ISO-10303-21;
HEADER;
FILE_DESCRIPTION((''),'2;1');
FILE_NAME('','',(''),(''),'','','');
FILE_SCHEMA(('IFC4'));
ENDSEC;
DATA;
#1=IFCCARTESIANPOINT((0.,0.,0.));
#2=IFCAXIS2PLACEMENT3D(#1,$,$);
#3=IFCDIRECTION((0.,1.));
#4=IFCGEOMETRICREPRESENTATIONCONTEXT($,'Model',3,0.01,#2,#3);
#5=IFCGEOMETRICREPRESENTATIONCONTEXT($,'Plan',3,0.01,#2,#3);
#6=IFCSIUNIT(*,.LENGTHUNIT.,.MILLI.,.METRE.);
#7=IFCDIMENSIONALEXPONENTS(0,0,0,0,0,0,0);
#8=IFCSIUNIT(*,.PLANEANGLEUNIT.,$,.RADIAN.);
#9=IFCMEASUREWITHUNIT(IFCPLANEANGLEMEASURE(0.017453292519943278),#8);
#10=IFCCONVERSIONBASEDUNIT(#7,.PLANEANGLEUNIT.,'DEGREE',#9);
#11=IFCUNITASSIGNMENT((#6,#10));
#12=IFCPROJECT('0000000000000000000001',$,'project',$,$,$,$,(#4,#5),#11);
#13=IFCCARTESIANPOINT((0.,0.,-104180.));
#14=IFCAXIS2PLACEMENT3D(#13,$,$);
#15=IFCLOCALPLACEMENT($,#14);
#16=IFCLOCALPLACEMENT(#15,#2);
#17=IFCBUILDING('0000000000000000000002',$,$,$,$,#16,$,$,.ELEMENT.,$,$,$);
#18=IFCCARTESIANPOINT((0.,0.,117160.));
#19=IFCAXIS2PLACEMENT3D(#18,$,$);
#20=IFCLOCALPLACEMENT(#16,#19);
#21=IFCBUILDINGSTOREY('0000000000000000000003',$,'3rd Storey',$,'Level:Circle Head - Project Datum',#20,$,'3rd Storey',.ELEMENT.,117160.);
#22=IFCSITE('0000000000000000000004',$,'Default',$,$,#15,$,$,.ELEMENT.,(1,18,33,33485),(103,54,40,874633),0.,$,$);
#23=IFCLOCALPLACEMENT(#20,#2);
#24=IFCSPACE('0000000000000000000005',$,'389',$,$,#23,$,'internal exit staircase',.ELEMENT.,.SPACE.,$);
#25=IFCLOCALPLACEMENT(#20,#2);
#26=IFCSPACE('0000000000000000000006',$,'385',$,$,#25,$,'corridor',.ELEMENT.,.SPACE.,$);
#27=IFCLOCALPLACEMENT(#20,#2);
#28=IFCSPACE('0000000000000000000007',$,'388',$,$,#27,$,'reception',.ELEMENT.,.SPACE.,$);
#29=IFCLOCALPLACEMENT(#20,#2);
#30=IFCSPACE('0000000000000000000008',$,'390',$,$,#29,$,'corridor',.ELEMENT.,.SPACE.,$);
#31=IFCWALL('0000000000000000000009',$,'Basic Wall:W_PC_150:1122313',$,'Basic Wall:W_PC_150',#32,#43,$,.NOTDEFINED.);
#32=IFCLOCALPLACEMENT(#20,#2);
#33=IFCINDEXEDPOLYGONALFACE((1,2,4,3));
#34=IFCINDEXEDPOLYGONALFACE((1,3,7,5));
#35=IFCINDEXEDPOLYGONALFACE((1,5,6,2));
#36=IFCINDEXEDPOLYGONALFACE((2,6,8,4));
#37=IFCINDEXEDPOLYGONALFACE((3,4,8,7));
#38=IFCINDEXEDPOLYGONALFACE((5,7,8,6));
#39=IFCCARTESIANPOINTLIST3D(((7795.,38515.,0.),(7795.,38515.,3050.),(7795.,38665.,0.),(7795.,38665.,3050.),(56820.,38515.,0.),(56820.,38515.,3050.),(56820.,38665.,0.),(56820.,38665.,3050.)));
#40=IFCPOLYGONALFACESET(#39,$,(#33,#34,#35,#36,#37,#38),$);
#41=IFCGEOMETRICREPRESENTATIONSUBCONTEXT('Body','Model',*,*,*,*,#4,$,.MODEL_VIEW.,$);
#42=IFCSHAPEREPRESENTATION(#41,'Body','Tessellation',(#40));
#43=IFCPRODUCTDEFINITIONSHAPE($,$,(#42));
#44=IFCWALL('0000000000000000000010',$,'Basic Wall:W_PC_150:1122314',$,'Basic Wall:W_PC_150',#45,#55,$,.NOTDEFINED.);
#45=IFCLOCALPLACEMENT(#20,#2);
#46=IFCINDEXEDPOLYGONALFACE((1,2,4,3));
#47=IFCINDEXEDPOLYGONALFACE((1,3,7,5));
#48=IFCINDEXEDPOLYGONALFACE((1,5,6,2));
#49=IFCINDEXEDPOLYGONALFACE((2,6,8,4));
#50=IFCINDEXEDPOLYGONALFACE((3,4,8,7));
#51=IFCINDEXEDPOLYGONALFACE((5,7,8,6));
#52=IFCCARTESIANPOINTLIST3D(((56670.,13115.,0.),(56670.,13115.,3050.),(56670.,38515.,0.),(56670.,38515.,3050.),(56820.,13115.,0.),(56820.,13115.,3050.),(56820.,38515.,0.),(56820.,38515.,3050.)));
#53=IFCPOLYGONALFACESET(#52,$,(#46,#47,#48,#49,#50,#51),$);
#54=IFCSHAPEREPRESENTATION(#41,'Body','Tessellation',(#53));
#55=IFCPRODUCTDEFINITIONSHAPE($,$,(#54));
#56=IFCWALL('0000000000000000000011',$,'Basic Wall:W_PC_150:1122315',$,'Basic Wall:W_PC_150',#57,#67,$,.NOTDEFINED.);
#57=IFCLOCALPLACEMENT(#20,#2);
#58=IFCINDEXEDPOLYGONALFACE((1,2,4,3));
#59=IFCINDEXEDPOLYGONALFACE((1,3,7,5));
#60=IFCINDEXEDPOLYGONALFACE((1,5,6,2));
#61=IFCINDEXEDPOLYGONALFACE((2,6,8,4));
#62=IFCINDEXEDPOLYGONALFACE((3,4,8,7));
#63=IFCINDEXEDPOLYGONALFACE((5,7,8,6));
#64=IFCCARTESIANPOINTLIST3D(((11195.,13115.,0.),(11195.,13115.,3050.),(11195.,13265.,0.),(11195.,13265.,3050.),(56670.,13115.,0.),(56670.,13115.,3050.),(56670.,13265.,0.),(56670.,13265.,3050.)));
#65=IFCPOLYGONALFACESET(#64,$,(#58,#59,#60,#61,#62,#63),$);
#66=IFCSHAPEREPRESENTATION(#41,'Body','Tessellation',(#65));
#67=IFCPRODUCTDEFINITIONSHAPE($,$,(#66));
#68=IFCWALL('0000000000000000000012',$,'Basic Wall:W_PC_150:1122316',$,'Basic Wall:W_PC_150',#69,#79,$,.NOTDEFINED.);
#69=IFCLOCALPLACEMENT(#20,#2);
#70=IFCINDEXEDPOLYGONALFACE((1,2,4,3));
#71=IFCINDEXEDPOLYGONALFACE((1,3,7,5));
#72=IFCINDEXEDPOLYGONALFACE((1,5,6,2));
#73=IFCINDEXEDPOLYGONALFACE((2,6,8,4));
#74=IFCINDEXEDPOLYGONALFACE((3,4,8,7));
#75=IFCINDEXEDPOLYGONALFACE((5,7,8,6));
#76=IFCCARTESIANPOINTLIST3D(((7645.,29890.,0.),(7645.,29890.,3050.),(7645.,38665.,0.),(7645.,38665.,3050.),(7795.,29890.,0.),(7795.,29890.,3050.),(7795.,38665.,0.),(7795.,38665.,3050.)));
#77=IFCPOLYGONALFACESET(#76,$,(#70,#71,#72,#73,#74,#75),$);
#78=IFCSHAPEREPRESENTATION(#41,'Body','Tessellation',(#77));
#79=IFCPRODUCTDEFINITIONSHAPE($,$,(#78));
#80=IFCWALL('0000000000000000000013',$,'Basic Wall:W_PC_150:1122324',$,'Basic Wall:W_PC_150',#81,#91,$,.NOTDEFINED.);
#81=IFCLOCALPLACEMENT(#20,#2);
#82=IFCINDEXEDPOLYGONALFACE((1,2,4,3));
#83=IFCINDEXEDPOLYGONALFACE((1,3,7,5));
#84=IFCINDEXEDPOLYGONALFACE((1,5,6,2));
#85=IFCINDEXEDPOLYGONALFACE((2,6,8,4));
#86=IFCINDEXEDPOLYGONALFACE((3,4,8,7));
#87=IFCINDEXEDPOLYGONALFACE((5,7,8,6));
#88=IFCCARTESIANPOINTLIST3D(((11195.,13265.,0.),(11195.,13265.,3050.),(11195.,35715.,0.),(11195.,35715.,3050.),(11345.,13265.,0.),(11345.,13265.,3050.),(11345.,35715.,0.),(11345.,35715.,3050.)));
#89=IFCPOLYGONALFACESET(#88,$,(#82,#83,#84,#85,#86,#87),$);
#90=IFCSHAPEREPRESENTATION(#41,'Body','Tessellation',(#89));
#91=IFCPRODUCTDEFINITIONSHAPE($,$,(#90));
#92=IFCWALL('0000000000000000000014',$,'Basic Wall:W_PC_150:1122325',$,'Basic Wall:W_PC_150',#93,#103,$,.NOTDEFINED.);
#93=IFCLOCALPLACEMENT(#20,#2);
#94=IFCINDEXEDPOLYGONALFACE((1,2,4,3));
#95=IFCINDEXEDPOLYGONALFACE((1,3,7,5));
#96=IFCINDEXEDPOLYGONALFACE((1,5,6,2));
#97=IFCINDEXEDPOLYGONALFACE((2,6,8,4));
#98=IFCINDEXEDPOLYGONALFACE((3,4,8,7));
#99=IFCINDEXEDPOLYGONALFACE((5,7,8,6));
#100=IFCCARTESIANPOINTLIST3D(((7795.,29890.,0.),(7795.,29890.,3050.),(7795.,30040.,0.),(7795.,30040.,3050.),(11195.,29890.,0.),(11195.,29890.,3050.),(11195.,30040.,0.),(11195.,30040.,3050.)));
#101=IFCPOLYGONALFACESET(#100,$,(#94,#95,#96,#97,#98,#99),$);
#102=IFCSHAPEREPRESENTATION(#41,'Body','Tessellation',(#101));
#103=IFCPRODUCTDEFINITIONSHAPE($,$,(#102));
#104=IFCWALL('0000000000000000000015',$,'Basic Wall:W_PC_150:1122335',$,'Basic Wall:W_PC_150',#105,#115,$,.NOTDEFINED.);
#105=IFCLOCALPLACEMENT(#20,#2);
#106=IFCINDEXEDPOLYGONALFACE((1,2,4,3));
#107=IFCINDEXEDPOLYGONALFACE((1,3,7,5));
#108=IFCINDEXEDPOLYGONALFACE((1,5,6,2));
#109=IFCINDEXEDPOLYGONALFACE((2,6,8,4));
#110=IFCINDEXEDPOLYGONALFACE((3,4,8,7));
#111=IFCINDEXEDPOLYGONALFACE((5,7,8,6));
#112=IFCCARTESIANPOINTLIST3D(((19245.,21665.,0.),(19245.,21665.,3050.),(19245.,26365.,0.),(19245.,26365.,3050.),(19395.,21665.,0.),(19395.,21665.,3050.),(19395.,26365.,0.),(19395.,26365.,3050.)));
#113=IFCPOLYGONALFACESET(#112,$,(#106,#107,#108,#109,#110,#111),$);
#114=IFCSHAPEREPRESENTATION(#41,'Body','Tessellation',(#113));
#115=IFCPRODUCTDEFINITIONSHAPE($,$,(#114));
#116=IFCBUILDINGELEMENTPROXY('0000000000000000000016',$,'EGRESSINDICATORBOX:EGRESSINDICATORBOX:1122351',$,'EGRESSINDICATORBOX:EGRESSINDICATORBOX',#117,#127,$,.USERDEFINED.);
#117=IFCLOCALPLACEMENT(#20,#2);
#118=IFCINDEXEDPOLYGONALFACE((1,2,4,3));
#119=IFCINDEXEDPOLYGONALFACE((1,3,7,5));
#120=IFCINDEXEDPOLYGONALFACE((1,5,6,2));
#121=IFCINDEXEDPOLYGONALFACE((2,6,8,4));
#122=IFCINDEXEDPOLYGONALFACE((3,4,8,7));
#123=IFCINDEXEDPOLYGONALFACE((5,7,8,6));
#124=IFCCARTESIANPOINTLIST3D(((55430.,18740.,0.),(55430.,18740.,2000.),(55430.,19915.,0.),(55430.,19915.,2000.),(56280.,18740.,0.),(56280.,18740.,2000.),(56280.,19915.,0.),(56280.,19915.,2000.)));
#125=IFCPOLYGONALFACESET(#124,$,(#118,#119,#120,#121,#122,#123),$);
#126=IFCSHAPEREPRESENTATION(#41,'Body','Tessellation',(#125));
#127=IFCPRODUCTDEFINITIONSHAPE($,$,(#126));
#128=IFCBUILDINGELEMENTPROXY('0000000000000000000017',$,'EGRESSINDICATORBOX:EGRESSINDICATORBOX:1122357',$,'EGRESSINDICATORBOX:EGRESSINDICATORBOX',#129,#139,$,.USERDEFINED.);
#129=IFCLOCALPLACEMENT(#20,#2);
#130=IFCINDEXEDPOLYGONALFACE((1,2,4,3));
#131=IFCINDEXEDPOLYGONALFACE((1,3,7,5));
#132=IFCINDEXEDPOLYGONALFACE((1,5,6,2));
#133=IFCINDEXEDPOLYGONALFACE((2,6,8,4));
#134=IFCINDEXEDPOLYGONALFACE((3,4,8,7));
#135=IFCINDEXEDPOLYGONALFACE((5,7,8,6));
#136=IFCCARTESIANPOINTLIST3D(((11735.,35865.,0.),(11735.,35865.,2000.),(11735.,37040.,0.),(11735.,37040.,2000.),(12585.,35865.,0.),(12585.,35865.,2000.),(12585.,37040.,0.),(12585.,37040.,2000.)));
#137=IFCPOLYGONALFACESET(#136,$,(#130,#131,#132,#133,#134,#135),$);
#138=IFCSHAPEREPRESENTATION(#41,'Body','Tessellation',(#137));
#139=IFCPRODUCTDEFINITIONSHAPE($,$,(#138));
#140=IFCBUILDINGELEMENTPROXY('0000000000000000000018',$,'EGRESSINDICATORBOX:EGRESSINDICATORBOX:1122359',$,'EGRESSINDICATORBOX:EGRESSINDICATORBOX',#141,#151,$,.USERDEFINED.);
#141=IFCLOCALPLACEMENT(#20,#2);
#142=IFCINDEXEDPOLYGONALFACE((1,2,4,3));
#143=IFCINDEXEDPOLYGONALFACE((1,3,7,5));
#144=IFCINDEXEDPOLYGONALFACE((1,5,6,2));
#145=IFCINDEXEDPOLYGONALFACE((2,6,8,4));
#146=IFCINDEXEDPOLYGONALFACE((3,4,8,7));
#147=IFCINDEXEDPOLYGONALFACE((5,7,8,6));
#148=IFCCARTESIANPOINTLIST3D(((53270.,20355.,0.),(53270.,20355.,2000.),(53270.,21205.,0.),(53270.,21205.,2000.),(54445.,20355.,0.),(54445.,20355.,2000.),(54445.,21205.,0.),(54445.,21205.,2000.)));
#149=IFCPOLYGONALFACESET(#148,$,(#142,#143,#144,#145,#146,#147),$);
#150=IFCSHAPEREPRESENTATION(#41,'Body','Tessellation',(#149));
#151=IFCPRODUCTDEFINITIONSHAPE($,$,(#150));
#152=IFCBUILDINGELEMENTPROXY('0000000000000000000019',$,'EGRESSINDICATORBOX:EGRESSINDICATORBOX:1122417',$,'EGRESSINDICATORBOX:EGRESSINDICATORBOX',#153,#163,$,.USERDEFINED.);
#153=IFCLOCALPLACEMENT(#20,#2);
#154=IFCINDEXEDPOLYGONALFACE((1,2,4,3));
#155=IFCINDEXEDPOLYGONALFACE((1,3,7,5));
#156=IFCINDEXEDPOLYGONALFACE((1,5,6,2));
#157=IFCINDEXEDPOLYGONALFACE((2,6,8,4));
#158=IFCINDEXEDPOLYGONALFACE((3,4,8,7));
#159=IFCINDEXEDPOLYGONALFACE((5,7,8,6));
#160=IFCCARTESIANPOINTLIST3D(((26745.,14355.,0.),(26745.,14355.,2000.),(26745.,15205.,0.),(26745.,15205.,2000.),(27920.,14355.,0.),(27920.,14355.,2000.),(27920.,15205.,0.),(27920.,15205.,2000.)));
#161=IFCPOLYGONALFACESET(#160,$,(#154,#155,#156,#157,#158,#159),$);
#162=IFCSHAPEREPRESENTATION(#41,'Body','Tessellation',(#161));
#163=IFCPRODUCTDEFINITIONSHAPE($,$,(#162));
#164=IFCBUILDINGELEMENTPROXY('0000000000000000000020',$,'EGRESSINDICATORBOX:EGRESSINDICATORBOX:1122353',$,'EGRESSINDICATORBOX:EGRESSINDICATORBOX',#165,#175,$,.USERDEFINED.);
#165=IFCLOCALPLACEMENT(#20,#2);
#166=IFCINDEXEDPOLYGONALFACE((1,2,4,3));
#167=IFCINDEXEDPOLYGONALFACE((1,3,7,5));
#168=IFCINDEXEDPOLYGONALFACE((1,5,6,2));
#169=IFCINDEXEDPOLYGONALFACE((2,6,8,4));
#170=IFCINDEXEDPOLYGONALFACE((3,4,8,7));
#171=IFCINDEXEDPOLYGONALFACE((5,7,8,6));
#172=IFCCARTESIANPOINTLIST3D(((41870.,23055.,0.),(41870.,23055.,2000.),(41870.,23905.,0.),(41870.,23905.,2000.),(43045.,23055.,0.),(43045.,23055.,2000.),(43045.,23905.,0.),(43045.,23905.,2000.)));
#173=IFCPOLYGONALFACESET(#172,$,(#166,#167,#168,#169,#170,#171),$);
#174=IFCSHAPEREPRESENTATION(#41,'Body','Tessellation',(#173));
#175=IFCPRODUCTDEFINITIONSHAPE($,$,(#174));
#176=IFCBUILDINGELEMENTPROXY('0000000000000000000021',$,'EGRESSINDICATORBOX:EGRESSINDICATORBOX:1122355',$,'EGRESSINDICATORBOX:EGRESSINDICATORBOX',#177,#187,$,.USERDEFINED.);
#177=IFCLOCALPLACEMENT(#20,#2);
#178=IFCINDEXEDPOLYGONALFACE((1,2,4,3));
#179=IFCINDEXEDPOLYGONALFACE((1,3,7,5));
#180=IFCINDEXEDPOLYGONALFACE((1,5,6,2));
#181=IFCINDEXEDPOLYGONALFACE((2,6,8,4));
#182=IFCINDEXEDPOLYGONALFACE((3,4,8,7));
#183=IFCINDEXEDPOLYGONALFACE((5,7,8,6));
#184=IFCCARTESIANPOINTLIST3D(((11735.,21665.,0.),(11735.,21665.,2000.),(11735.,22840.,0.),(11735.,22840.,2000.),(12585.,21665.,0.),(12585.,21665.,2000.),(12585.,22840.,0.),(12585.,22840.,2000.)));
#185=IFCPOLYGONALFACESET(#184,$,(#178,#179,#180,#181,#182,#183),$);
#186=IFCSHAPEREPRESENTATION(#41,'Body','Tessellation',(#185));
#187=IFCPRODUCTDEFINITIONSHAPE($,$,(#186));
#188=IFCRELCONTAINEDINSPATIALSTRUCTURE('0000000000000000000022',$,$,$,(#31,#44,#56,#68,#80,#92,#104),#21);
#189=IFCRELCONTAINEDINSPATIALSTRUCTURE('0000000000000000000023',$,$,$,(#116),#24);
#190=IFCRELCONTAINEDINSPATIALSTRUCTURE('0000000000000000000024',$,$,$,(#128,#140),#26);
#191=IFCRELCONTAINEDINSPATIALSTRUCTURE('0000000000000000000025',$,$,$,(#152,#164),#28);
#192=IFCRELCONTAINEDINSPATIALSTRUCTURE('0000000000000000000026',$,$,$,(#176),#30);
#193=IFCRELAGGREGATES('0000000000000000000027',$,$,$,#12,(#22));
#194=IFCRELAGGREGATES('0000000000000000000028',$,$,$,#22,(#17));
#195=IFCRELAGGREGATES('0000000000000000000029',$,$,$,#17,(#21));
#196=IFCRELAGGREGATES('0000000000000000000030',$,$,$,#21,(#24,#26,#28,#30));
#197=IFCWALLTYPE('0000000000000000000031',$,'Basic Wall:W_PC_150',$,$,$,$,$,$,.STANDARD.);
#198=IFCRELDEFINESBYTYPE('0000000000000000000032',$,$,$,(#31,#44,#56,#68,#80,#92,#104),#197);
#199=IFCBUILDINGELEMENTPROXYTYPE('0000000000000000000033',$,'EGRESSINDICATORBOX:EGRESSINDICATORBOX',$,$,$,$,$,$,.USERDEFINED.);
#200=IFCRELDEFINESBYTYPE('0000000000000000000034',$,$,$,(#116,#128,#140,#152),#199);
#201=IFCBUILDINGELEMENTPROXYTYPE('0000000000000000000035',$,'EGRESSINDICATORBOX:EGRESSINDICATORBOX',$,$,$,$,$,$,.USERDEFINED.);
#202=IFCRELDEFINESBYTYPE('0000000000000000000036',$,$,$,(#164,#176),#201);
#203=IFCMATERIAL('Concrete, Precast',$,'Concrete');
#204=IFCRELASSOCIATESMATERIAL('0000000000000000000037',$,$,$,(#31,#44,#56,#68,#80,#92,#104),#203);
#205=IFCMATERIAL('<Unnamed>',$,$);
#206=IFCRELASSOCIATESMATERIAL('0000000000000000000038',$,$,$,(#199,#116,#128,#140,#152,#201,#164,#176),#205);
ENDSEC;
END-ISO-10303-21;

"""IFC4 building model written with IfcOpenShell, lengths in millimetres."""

from ifc_helpers import new_model, entity, si_unit, converted_unit, direction, frame, origin, place, context, subcontext, project, spatial, indexed_curve, outline, extrude, source, transform, mapped, material, type_object, type_shapes, element, save


model = new_model("IFC4")

# Units and contexts
model_context = context("Model", 3, precision=0.01, world=origin(), true_north=direction((0.0, 1.0)))
plan_context = context("Plan", 3, precision=0.01, world=origin(), true_north=direction((0.0, 1.0)))
body_context = subcontext(model_context, "Body", "Model", "MODEL_VIEW")
ifc_project = project(units=[si_unit("LENGTHUNIT", "METRE", prefix="MILLI"), converted_unit("PLANEANGLEUNIT", "DEGREE", entity("IfcPlaneAngleMeasure", 0.017453292519943278), si_unit("PLANEANGLEUNIT", "RADIAN"), dimensions=[0, 0, 0, 0, 0, 0, 0])], contexts=[model_context, plan_context])

# Site, building, storey
site_placement = place(None, frame((0.0, 0.0, -104180.0)))
site = spatial("IfcSite", under=ifc_project, at=site_placement, Name="Default", CompositionType="ELEMENT", RefLatitude=(1, 18, 33, 33485), RefLongitude=(103, 54, 40, 874633), RefElevation=0.0)
building_placement = place(site_placement, origin())
building = spatial("IfcBuilding", under=site, at=building_placement, CompositionType="ELEMENT")
storey_placement = place(building_placement, frame((0.0, 0.0, 117160.0)))
storey = spatial("IfcBuildingStorey", under=building, at=storey_placement, Name="3rd Storey", ObjectType="Level:Circle Head - Project Datum", LongName="3rd Storey", CompositionType="ELEMENT", Elevation=117160.0)

# Shared definitions
ifc_material_1 = material(Name="Concrete, Precast", Category="Concrete")

# Walls
wall_type = type_object("IfcWallType", Name="Basic Wall:W_PC_150", PredefinedType="STANDARD")
wall_1_placement = place(storey_placement, frame((56820.0, 38590.0, 0.0), z_axis=(0.0, 0.0, 1.0), x_axis=(-1.0, 0.0, 0.0)))
element("IfcWall", 1, at=wall_1_placement, inside=storey, type_object=wall_type, material=ifc_material_1, Name="Basic Wall:W_PC_150:1122313", ObjectType="Basic Wall:W_PC_150", PredefinedType="NOTDEFINED", context=body_context, shape_type="SweptSolid", body=[
    extrude(outline(indexed_curve([(49025.0, 75.0), (0.0, 75.0), (0.0, -75.0), (49025.0, -75.0), (49025.0, 75.0)], self_intersect=False)), origin(), (0.0, 0.0, 1.0), 3050.0),
])
wall_2_placement = place(storey_placement, frame((56745.0, 13115.0, 0.0), z_axis=(0.0, 0.0, 1.0), x_axis=(0.0, 1.0, 0.0)))
element("IfcWall", 2, at=wall_2_placement, inside=storey, type_object=wall_type, material=ifc_material_1, Name="Basic Wall:W_PC_150:1122314", ObjectType="Basic Wall:W_PC_150", PredefinedType="NOTDEFINED", context=body_context, shape_type="SweptSolid", body=[
    extrude(outline(indexed_curve([(25400.0, 75.0), (0.0, 75.0), (0.0, -75.0), (25400.0, -75.0), (25400.0, 75.0)], self_intersect=False)), origin(), (0.0, 0.0, 1.0), 3050.0),
])
wall_3_placement = place(storey_placement, frame((11195.0, 13190.0, 0.0)))
element("IfcWall", 3, at=wall_3_placement, inside=storey, type_object=wall_type, material=ifc_material_1, Name="Basic Wall:W_PC_150:1122315", ObjectType="Basic Wall:W_PC_150", PredefinedType="NOTDEFINED", context=body_context, shape_type="SweptSolid", body=[
    extrude(outline(indexed_curve([(45475.0, 75.0), (0.0, 75.0), (0.0, -75.0), (45475.0, -75.0), (45475.0, 75.0)], self_intersect=False)), origin(), (0.0, 0.0, 1.0), 3050.0),
])
wall_4_placement = place(storey_placement, frame((7720.0, 38665.0, 0.0), z_axis=(0.0, 0.0, 1.0), x_axis=(0.0, -1.0, 0.0)))
element("IfcWall", 4, at=wall_4_placement, inside=storey, type_object=wall_type, material=ifc_material_1, Name="Basic Wall:W_PC_150:1122316", ObjectType="Basic Wall:W_PC_150", PredefinedType="NOTDEFINED", context=body_context, shape_type="SweptSolid", body=[
    extrude(outline(indexed_curve([(8775.0, 75.0), (0.0, 75.0), (0.0, -75.0), (8775.0, -75.0), (8775.0, 75.0)], self_intersect=False)), origin(), (0.0, 0.0, 1.0), 3050.0),
])
wall_5_placement = place(storey_placement, frame((11270.0, 35715.0, 0.0), z_axis=(0.0, 0.0, 1.0), x_axis=(0.0, -1.0, 0.0)))
element("IfcWall", 5, at=wall_5_placement, inside=storey, type_object=wall_type, material=ifc_material_1, Name="Basic Wall:W_PC_150:1122324", ObjectType="Basic Wall:W_PC_150", PredefinedType="NOTDEFINED", context=body_context, shape_type="SweptSolid", body=[
    extrude(outline(indexed_curve([(22450.0, 75.0), (0.0, 75.0), (0.0, -75.0), (22450.0, -75.0), (22450.0, 75.0)], self_intersect=False)), origin(), (0.0, 0.0, 1.0), 3050.0),
])
wall_6_placement = place(storey_placement, frame((7795.0, 29965.0, 0.0)))
element("IfcWall", 6, at=wall_6_placement, inside=storey, type_object=wall_type, material=ifc_material_1, Name="Basic Wall:W_PC_150:1122325", ObjectType="Basic Wall:W_PC_150", PredefinedType="NOTDEFINED", context=body_context, shape_type="SweptSolid", body=[
    extrude(outline(indexed_curve([(3400.0, 75.0), (0.0, 75.0), (0.0, -75.0), (3400.0, -75.0), (3400.0, 75.0)], self_intersect=False)), origin(), (0.0, 0.0, 1.0), 3050.0),
])
wall_7_placement = place(storey_placement, frame((19320.0, 21665.0, 0.0), z_axis=(0.0, 0.0, 1.0), x_axis=(0.0, 1.0, 0.0)))
element("IfcWall", 7, at=wall_7_placement, inside=storey, type_object=wall_type, material=ifc_material_1, Name="Basic Wall:W_PC_150:1122335", ObjectType="Basic Wall:W_PC_150", PredefinedType="NOTDEFINED", context=body_context, shape_type="SweptSolid", body=[
    extrude(outline(indexed_curve([(4700.0, 75.0), (0.0, 75.0), (0.0, -75.0), (4700.0, -75.0), (4700.0, 75.0)], self_intersect=False)), origin(), (0.0, 0.0, 1.0), 3050.0),
])

# Shared definitions
space_1_placement = place(storey_placement, origin())
space_1 = spatial("IfcSpace", under=storey, at=space_1_placement, Name="389", LongName="internal exit staircase", CompositionType="ELEMENT", PredefinedType="SPACE")

# Building element proxy
ifc_material_2 = material(Name="<Unnamed>")
building_element_proxy_type_1 = type_object("IfcBuildingElementProxyType", Name="EGRESSINDICATORBOX:EGRESSINDICATORBOX", PredefinedType="USERDEFINED", material=ifc_material_2)
shared_shape_1 = source(origin(), body_context, "Body", "SweptSolid", [
    extrude(outline(indexed_curve([(-587.5, -425.0), (587.5, -425.0), (587.5, 425.0), (-587.5, 425.0), (-587.5, -425.0)], self_intersect=False)), frame((0.0, 0.0, 0.0), z_axis=(0.0, 0.0, 1.0), x_axis=(0.0, 1.0, 0.0)), (0.0, 0.0, 1.0), 2000.0),
])
type_shapes(building_element_proxy_type_1, [shared_shape_1])
proxy_1_placement = place(space_1_placement, frame((55855.0, 19327.5, 0.0)))
element("IfcBuildingElementProxy", 8, at=proxy_1_placement, inside=space_1, type_object=building_element_proxy_type_1, material=ifc_material_2, Name="EGRESSINDICATORBOX:EGRESSINDICATORBOX:1122351", ObjectType="EGRESSINDICATORBOX:EGRESSINDICATORBOX", PredefinedType="USERDEFINED", context=body_context, shape_type="MappedRepresentation", body=[
    mapped(shared_shape_1, transform((0.0, 0.0, 0.0), scale=1.0)),
])

# Shared definitions
space_2_placement = place(storey_placement, origin())
space_2 = spatial("IfcSpace", under=storey, at=space_2_placement, Name="385", LongName="corridor", CompositionType="ELEMENT", PredefinedType="SPACE")

# Building element proxies
for number, where, z_axis, x_axis, name in (
    (9, (12160.0, 36452.5, 0.0), (0.0, 0.0, 1.0), (-1.0, 0.0, 0.0), "EGRESSINDICATORBOX:EGRESSINDICATORBOX:1122357"),
    (10, (53857.5, 20780.0, 0.0), (0.0, 0.0, 1.0), (0.0, 1.0, 0.0), "EGRESSINDICATORBOX:EGRESSINDICATORBOX:1122359"),
):
    element("IfcBuildingElementProxy", number, at=place(space_2_placement, frame(where, z_axis=z_axis, x_axis=x_axis)), inside=space_2, type_object=building_element_proxy_type_1, material=ifc_material_2, Name=name, ObjectType="EGRESSINDICATORBOX:EGRESSINDICATORBOX", PredefinedType="USERDEFINED", context=body_context, shape_type="MappedRepresentation", body=[
        mapped(shared_shape_1, transform((0.0, 0.0, 0.0), scale=1.0)),
    ])

# Shared definitions
space_3_placement = place(storey_placement, origin())
space_3 = spatial("IfcSpace", under=storey, at=space_3_placement, Name="388", LongName="reception", CompositionType="ELEMENT", PredefinedType="SPACE")

# Building element proxies
proxy_2_placement = place(space_3_placement, frame((27332.5, 14780.0, 0.0), z_axis=(0.0, 0.0, 1.0), x_axis=(0.0, 1.0, 0.0)))
element("IfcBuildingElementProxy", 11, at=proxy_2_placement, inside=space_3, type_object=building_element_proxy_type_1, material=ifc_material_2, Name="EGRESSINDICATORBOX:EGRESSINDICATORBOX:1122417", ObjectType="EGRESSINDICATORBOX:EGRESSINDICATORBOX", PredefinedType="USERDEFINED", context=body_context, shape_type="MappedRepresentation", body=[
    mapped(shared_shape_1, transform((0.0, 0.0, 0.0), scale=1.0)),
])
building_element_proxy_type_2 = type_object("IfcBuildingElementProxyType", Name="EGRESSINDICATORBOX:EGRESSINDICATORBOX", PredefinedType="USERDEFINED", material=ifc_material_2)
shared_shape_2 = source(origin(), body_context, "Body", "SweptSolid", [
    extrude(outline(indexed_curve([(-425.0, -587.5), (425.0, -587.5), (425.0, 587.5), (-425.0, 587.5), (-425.0, -587.5)], self_intersect=False)), frame((0.0, 0.0, 0.0), z_axis=(0.0, 0.0, 1.0), x_axis=(-1.0, 0.0, 0.0)), (0.0, 0.0, 1.0), 2000.0),
])
type_shapes(building_element_proxy_type_2, [shared_shape_2])
proxy_3_placement = place(space_3_placement, frame((42457.5, 23480.0, 0.0), z_axis=(0.0, 0.0, 1.0), x_axis=(0.0, -1.0, 0.0)))
element("IfcBuildingElementProxy", 12, at=proxy_3_placement, inside=space_3, type_object=building_element_proxy_type_2, material=ifc_material_2, Name="EGRESSINDICATORBOX:EGRESSINDICATORBOX:1122353", ObjectType="EGRESSINDICATORBOX:EGRESSINDICATORBOX", PredefinedType="USERDEFINED", context=body_context, shape_type="MappedRepresentation", body=[
    mapped(shared_shape_2, transform((0.0, 0.0, 0.0), scale=1.0)),
])

# Shared definitions
space_4_placement = place(storey_placement, origin())
space_4 = spatial("IfcSpace", under=storey, at=space_4_placement, Name="390", LongName="corridor", CompositionType="ELEMENT", PredefinedType="SPACE")

# Building element proxy
proxy_4_placement = place(space_4_placement, frame((12160.0, 22252.5, 0.0)))
element("IfcBuildingElementProxy", 13, at=proxy_4_placement, inside=space_4, type_object=building_element_proxy_type_2, material=ifc_material_2, Name="EGRESSINDICATORBOX:EGRESSINDICATORBOX:1122355", ObjectType="EGRESSINDICATORBOX:EGRESSINDICATORBOX", PredefinedType="USERDEFINED", context=body_context, shape_type="MappedRepresentation", body=[
    mapped(shared_shape_2, transform((0.0, 0.0, 0.0), scale=1.0)),
])

save(model, "model.ifc")
